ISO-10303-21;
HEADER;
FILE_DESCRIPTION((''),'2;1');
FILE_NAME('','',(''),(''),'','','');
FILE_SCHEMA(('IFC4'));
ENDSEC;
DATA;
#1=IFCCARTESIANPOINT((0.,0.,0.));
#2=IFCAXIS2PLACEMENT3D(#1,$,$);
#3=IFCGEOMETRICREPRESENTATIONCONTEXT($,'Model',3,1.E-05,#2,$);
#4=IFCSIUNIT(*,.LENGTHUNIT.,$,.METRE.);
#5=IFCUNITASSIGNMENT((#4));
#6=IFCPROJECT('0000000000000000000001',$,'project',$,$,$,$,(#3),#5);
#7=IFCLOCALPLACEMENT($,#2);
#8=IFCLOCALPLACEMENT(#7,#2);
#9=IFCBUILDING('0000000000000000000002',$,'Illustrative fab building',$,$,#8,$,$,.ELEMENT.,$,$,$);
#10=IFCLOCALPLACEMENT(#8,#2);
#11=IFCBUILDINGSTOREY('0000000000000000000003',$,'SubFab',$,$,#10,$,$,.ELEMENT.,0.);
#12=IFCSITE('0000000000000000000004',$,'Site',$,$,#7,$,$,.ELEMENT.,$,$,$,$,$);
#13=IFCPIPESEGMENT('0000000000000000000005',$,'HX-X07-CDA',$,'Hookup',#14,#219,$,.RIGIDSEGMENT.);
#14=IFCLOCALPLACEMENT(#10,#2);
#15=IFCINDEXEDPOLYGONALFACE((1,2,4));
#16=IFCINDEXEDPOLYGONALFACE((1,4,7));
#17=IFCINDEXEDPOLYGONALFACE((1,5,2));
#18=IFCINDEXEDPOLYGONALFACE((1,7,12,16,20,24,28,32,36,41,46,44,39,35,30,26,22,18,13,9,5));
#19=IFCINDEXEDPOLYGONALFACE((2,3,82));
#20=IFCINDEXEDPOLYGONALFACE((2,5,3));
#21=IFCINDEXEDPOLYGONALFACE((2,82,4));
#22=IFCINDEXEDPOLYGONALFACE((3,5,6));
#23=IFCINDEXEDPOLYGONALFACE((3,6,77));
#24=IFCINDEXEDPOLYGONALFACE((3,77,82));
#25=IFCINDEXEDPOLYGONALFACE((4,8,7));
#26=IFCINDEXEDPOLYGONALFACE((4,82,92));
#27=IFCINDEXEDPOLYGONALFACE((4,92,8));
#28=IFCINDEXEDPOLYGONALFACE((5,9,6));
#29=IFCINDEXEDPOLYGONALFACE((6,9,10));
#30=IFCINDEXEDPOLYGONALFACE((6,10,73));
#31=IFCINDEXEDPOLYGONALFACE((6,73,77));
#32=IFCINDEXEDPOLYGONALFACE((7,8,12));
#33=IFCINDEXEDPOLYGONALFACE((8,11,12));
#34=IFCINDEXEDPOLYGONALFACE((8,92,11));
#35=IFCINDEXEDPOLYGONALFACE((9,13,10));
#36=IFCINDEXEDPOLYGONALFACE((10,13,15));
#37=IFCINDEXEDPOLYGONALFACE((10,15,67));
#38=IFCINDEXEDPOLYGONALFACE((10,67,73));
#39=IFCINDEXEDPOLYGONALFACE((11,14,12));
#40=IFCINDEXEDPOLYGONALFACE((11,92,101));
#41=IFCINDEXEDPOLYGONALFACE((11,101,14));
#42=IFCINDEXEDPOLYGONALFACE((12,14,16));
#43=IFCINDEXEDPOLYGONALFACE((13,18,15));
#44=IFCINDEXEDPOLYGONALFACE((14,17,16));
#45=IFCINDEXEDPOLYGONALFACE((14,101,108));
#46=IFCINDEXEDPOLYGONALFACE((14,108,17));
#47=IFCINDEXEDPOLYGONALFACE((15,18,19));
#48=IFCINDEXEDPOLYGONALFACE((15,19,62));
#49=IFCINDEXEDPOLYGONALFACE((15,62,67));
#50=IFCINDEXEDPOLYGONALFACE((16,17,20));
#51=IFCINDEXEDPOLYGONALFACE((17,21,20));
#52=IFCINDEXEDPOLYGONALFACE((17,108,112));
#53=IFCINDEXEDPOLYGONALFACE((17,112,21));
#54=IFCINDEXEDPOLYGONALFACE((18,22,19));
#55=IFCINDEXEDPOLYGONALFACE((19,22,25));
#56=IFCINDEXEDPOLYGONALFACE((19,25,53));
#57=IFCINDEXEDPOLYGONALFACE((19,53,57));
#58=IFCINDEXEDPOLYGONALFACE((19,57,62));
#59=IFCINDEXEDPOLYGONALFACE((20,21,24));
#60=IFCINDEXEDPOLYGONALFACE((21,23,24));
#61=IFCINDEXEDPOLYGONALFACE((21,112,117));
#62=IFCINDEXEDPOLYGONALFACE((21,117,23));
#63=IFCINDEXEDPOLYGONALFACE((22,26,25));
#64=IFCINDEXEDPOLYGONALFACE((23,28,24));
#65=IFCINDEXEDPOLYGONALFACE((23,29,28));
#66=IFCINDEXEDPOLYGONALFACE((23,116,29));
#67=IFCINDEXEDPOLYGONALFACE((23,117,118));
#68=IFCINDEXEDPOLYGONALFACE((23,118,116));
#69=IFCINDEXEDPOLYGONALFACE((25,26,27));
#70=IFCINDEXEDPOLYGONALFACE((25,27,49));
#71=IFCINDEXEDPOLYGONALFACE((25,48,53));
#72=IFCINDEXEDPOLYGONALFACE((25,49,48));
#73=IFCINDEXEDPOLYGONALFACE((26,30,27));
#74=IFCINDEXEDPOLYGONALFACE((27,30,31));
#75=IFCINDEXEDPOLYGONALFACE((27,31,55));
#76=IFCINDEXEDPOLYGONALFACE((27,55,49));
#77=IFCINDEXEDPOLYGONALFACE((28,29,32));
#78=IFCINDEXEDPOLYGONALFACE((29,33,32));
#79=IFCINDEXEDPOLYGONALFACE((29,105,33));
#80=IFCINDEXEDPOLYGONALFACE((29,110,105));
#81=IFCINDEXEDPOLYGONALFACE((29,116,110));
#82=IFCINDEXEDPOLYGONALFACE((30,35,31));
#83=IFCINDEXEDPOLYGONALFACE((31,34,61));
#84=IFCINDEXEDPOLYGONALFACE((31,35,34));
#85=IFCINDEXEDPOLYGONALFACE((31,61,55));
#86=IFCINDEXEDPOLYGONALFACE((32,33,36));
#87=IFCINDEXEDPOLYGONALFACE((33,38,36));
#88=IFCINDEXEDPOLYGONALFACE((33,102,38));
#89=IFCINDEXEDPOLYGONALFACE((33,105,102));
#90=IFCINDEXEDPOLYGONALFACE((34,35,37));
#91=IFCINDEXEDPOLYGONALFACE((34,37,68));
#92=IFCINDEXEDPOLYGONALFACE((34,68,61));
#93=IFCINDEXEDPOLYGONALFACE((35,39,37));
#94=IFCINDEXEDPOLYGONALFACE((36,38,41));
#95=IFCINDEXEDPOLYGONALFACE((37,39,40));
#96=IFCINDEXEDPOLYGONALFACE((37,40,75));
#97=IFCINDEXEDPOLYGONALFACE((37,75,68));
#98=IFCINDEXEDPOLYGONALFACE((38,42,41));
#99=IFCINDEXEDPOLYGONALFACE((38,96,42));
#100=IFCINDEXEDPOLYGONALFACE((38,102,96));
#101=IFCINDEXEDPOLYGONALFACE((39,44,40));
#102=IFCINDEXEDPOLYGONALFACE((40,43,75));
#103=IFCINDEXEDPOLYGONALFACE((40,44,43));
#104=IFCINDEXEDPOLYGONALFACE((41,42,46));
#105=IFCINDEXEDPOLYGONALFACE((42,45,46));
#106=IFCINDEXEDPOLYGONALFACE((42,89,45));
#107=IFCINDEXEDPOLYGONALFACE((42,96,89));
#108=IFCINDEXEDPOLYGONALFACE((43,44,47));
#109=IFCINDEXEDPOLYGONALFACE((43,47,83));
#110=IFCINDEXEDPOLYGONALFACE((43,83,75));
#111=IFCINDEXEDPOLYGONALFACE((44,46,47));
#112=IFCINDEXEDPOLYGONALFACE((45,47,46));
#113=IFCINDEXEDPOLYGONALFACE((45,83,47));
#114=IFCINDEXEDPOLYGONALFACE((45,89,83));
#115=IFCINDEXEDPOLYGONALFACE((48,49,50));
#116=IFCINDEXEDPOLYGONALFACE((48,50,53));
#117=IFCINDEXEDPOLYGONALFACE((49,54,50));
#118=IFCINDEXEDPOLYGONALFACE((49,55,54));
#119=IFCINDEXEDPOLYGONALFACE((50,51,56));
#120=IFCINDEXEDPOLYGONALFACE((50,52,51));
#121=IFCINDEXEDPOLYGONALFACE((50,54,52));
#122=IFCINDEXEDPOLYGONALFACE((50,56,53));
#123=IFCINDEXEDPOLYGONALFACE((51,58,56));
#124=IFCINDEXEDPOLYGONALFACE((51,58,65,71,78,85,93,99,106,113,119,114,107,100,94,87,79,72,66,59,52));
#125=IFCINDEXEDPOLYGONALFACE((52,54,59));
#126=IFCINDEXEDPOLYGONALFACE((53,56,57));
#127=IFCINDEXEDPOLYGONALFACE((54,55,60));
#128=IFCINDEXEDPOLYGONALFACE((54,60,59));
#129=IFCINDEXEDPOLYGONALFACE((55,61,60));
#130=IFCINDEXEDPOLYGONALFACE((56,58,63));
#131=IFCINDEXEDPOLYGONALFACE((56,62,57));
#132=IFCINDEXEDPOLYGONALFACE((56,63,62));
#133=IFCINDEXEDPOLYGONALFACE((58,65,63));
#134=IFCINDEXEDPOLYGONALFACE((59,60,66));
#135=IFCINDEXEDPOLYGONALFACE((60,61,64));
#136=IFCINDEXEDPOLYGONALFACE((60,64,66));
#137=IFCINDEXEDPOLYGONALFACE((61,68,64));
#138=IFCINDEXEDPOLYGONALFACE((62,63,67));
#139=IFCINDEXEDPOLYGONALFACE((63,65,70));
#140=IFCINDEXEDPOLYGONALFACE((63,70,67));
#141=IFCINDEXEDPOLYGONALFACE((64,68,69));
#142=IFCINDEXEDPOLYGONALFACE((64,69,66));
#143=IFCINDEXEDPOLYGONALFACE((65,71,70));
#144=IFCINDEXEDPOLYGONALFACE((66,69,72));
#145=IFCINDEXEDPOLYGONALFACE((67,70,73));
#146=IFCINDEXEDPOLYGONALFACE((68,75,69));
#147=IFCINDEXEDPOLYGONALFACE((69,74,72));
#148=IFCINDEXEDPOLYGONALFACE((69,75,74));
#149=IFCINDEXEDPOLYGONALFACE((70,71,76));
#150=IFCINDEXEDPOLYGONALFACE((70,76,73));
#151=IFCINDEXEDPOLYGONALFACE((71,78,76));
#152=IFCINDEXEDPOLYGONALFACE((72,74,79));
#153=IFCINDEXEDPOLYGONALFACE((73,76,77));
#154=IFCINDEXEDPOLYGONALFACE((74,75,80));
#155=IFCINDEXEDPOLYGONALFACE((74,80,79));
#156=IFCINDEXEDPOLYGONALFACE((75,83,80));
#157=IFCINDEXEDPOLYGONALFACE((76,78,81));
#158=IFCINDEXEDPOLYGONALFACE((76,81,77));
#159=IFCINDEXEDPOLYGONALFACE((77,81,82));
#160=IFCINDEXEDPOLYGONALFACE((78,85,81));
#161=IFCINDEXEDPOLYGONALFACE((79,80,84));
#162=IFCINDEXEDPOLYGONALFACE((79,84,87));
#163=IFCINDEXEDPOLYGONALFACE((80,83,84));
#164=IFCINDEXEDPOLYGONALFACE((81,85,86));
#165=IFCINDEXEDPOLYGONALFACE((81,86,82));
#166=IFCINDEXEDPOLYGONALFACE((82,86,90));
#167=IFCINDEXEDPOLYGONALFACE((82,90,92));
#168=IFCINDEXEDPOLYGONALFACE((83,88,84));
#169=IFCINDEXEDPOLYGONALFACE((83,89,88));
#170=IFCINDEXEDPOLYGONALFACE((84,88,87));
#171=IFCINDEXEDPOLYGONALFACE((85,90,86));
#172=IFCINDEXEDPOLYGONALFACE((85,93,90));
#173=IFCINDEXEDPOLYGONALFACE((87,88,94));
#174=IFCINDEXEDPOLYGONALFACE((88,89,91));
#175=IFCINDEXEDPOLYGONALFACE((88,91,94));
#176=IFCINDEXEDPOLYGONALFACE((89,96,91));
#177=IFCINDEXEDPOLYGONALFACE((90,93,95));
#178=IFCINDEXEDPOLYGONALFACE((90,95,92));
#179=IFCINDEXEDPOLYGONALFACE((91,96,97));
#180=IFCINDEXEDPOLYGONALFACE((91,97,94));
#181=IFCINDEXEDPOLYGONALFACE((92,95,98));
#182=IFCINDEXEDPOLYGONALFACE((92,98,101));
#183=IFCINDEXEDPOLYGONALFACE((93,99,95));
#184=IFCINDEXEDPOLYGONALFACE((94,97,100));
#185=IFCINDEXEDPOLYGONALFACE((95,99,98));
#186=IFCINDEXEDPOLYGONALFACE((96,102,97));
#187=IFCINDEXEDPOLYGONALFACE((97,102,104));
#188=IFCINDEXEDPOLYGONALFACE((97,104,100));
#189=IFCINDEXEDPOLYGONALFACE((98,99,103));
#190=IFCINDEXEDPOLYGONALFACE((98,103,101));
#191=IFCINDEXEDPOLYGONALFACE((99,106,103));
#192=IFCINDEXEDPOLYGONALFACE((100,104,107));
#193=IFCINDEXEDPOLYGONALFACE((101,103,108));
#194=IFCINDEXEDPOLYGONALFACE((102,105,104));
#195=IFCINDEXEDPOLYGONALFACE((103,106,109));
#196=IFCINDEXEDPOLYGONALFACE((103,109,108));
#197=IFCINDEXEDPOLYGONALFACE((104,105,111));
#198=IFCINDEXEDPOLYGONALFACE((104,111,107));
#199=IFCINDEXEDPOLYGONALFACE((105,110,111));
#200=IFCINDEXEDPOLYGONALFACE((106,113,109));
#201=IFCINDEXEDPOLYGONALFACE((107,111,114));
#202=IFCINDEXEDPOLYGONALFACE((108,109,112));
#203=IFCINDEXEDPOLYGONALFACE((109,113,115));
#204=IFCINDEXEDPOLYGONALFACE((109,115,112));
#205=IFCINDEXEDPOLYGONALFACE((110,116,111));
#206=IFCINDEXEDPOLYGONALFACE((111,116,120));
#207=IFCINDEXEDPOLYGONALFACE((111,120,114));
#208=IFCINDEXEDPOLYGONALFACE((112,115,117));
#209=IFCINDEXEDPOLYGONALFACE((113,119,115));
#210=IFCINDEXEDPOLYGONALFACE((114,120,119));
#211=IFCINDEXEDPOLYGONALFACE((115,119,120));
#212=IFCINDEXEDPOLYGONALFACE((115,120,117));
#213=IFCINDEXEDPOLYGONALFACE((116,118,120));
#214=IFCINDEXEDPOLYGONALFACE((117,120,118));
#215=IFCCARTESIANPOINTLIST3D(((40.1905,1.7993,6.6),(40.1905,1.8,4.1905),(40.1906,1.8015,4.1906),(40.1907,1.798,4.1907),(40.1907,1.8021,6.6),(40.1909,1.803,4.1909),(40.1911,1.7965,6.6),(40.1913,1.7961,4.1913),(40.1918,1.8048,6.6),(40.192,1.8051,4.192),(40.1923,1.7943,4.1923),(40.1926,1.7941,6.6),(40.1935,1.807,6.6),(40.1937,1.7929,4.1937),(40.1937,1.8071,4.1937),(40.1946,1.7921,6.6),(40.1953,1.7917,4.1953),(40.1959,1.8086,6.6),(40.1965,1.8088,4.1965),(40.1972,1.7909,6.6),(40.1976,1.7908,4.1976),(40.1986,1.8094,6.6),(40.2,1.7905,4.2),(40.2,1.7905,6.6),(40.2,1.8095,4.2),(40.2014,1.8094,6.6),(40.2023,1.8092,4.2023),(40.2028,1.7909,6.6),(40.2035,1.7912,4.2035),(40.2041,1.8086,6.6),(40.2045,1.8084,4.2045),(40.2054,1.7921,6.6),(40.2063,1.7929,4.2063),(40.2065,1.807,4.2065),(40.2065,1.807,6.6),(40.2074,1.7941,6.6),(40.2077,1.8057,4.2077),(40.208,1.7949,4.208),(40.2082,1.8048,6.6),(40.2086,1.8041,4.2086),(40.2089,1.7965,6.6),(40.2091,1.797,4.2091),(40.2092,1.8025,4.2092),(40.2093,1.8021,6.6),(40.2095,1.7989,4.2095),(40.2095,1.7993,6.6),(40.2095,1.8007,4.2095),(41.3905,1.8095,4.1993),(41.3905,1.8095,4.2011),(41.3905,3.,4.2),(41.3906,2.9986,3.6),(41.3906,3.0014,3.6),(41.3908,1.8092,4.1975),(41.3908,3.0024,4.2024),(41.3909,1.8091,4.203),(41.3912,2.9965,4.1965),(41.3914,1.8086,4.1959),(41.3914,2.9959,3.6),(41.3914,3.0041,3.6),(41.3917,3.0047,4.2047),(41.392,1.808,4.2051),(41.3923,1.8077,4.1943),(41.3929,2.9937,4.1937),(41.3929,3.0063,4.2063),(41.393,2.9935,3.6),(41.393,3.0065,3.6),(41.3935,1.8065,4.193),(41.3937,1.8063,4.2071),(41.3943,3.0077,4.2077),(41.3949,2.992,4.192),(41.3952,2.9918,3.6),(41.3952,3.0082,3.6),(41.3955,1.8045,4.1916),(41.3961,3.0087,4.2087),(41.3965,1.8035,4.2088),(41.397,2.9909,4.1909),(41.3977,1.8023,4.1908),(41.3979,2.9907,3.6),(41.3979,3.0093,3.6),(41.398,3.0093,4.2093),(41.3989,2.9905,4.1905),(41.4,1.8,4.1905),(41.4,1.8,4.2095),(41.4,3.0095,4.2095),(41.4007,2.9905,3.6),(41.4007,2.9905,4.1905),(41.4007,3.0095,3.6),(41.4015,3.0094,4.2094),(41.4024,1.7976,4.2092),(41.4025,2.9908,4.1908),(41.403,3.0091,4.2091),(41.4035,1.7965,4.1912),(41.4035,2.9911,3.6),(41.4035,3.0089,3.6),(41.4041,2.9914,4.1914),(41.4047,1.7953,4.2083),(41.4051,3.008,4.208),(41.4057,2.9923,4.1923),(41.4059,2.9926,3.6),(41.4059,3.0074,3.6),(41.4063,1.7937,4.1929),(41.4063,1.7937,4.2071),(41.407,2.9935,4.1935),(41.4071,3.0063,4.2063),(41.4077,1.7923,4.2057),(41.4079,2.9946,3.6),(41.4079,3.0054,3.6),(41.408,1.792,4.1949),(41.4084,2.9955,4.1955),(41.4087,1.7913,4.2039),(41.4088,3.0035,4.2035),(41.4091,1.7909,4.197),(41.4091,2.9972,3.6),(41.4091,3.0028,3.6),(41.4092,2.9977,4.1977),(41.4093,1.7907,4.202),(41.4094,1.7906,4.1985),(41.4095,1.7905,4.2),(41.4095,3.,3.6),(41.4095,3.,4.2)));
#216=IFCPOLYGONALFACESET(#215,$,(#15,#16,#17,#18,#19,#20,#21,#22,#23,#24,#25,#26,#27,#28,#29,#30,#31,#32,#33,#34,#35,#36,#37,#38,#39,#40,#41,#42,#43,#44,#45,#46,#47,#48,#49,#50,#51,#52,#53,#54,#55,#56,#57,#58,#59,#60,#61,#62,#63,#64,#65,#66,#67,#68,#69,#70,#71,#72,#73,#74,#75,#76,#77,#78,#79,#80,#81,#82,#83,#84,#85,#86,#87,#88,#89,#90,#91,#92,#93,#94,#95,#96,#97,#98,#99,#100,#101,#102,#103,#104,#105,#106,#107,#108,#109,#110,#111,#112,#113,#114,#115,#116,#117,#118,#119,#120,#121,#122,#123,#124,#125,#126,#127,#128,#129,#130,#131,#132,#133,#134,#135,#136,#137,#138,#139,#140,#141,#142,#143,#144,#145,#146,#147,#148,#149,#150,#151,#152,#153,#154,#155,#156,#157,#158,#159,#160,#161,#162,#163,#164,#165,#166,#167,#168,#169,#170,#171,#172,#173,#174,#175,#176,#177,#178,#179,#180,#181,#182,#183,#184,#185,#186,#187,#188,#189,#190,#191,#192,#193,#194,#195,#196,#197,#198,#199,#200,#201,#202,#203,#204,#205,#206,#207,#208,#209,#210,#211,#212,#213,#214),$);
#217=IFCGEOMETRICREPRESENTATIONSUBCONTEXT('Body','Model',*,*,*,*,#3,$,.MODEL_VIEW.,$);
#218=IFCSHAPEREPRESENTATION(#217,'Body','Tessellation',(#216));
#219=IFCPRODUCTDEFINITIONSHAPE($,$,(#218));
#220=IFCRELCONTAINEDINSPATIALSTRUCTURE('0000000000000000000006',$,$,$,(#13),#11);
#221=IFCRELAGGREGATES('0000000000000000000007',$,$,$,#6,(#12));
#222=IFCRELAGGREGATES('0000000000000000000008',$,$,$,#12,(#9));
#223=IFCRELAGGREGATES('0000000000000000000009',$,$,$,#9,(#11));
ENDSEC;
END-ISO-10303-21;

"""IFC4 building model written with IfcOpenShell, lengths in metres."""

from ifc_helpers import new_model, entity, si_unit, origin, place, context, subcontext, project, spatial, element, save


model = new_model("IFC4")

# Units and contexts
model_context = context("Model", 3, precision=1e-05, world=origin())
body_context = subcontext(model_context, "Body", "Model", "MODEL_VIEW")
ifc_project = project(units=[si_unit("LENGTHUNIT", "METRE")], contexts=[model_context])

# Site, building, storey
site_placement = place(None, origin())
site = spatial("IfcSite", under=ifc_project, at=site_placement, Name="Site", CompositionType="ELEMENT")
building_placement = place(site_placement, origin())
building = spatial("IfcBuilding", under=site, at=building_placement, Name="Illustrative fab building", CompositionType="ELEMENT")
storey_placement = place(building_placement, origin())
storey = spatial("IfcBuildingStorey", under=building, at=storey_placement, Name="SubFab", CompositionType="ELEMENT", Elevation=0.0)

# Pipe segment
pipe_segment_1_placement = place(storey_placement, origin())
element("IfcPipeSegment", 1, at=pipe_segment_1_placement, inside=storey, Name="HX-X07-CDA", ObjectType="Hookup", PredefinedType="RIGIDSEGMENT", context=body_context, shape_type="AdvancedSweptSolid", body=[
    entity("IfcSweptDiskSolid", entity("IfcPolyline", [entity("IfcCartesianPoint", [41.4, 3.0, 3.6]), entity("IfcCartesianPoint", [41.4, 3.0, 4.2]), entity("IfcCartesianPoint", [41.4, 1.8, 4.2]), entity("IfcCartesianPoint", [40.2, 1.8, 4.2]), entity("IfcCartesianPoint", [40.2, 1.8, 6.6])]), 0.0095),
])

save(model, "model.ifc")
